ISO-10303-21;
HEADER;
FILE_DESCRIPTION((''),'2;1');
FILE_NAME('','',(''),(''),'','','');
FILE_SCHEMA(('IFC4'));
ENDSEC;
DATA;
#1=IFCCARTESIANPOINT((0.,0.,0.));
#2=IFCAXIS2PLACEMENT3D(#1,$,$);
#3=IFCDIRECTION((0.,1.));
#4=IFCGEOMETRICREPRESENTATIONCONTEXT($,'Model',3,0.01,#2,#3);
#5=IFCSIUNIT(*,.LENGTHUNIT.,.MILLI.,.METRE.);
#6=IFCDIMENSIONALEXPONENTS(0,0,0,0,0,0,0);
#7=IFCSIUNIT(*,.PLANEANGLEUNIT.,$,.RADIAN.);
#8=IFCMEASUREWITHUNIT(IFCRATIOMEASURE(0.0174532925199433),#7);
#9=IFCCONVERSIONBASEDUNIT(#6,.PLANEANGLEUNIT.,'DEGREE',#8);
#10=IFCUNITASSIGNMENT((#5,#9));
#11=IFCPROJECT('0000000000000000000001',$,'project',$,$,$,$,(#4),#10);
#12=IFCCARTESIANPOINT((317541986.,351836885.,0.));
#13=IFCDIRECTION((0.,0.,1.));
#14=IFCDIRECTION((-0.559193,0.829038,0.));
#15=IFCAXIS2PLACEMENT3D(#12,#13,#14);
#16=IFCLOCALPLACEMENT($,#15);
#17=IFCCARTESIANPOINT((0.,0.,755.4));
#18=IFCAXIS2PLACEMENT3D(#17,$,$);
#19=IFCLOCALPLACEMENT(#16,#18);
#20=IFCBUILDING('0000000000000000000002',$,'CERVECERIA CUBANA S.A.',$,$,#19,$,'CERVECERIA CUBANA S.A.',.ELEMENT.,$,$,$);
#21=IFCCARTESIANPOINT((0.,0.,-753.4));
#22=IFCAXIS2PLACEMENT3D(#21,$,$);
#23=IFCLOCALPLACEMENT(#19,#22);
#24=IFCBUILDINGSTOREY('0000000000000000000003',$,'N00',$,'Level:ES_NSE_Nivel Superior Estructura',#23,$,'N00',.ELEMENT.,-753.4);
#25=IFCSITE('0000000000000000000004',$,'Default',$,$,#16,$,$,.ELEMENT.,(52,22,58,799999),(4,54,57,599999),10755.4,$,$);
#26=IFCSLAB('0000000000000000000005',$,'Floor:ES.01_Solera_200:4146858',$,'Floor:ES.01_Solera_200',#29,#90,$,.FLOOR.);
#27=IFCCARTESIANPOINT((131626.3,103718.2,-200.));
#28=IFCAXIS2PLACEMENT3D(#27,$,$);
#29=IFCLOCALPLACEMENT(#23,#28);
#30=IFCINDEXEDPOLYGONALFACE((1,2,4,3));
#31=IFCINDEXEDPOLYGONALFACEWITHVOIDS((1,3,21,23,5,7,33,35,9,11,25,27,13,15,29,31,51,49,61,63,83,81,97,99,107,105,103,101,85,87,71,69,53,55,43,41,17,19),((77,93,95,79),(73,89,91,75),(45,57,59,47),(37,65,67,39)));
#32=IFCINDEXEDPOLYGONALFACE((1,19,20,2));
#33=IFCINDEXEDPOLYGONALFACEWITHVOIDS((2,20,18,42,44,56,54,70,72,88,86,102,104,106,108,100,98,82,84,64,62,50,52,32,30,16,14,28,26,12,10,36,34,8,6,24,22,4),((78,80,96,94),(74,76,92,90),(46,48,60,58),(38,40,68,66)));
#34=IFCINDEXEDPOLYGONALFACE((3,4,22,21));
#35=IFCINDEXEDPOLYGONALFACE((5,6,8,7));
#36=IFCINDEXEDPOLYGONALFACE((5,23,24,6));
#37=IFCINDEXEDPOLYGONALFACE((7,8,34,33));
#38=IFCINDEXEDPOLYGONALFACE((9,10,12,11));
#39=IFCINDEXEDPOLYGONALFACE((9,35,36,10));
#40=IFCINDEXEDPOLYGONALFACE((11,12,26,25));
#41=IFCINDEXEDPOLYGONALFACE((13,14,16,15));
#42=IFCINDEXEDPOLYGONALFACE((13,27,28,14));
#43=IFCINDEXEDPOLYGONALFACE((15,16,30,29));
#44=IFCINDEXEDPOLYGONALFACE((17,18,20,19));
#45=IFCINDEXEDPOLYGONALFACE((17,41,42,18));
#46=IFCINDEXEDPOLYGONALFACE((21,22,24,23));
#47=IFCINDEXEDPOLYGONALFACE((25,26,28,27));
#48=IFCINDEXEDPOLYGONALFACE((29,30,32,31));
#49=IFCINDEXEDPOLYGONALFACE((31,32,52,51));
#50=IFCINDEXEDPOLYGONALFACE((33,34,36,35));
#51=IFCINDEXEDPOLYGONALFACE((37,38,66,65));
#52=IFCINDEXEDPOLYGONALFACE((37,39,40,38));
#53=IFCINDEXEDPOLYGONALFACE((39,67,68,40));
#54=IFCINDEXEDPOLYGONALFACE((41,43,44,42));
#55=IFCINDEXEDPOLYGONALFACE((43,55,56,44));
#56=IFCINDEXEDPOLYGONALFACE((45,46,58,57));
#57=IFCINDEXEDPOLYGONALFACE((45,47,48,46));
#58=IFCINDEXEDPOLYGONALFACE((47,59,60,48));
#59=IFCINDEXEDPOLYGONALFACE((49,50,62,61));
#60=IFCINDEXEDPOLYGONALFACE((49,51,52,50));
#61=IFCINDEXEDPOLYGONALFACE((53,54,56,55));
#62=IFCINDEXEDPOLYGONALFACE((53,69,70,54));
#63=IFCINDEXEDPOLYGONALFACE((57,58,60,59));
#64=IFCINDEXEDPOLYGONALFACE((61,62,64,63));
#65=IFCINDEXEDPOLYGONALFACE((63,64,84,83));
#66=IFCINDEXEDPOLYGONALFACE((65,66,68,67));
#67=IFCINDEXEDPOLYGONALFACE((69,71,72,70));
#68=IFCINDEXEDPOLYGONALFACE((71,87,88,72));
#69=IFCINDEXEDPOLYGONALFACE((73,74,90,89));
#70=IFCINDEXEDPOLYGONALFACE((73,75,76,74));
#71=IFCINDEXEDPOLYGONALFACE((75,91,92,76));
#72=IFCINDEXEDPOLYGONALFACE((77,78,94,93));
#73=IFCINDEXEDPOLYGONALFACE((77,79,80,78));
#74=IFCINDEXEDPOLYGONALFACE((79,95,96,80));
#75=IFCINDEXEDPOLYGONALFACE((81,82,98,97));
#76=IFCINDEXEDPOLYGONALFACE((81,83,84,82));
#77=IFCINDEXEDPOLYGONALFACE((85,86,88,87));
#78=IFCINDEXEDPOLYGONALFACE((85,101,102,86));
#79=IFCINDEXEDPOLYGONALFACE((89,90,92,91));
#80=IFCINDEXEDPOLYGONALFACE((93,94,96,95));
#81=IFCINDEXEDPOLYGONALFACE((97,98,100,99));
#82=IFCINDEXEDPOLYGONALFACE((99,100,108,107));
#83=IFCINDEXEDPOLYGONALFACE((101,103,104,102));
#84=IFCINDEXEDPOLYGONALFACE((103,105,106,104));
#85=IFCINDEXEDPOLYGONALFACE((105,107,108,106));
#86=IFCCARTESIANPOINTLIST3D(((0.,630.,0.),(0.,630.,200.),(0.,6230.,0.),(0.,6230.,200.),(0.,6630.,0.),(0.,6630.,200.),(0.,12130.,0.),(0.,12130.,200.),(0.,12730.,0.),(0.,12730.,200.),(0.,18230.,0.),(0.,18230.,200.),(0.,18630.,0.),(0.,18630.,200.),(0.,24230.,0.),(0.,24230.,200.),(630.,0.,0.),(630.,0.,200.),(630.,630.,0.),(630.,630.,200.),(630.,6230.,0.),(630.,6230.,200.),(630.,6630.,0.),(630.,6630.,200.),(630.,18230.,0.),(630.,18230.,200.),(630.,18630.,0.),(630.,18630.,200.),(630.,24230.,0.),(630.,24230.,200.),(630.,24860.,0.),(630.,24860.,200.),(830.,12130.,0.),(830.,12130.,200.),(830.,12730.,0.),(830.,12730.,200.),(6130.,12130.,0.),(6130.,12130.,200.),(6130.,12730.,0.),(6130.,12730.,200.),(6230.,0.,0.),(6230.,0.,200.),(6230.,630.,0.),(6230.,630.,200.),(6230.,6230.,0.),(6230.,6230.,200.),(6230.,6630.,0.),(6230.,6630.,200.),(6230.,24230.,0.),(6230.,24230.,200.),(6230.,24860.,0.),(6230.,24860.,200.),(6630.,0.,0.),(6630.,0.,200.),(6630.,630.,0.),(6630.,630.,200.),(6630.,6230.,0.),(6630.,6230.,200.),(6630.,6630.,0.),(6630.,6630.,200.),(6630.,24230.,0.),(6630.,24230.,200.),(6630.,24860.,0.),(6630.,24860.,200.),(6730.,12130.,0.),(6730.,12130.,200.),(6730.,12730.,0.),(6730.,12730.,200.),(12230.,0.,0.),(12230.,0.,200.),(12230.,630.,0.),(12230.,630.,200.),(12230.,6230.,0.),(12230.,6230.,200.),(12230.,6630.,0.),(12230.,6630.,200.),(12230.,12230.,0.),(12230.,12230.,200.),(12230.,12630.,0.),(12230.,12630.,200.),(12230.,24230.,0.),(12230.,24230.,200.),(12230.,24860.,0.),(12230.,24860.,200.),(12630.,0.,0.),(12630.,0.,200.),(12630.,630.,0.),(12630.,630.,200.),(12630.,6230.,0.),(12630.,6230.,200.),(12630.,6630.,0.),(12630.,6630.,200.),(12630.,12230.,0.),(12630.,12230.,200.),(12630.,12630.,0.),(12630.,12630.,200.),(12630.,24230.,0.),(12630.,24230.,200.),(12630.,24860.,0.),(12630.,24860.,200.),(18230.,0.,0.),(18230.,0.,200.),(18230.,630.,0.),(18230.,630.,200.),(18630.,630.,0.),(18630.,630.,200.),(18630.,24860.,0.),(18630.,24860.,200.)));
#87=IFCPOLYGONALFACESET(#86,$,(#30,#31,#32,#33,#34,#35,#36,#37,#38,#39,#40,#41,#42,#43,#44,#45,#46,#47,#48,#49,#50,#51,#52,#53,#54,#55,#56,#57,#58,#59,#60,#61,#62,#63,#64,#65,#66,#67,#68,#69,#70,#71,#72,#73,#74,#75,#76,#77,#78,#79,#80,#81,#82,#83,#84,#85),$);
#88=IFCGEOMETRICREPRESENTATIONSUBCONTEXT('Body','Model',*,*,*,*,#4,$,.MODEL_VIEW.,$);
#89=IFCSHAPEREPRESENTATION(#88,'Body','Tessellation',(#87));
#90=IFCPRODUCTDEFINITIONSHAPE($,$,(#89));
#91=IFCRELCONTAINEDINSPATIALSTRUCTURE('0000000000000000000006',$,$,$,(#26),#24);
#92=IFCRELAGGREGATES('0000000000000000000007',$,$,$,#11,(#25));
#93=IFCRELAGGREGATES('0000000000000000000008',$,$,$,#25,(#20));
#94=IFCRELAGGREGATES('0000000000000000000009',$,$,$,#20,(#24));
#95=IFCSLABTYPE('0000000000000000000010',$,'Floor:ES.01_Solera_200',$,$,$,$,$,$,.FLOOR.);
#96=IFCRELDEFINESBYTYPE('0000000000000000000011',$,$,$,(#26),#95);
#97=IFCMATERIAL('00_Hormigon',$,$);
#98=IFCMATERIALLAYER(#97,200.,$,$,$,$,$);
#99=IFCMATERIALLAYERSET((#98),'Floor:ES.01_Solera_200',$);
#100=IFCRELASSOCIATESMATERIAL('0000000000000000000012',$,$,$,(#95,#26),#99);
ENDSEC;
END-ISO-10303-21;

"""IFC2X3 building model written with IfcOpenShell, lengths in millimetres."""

from ifc_helpers import new_model, entity, si_unit, converted_unit, direction, frame, origin, origin_2d_with_axis, place, context, subcontext, project, spatial, polyline, rectangle, outline, extrude, material, layer, layer_set, layer_usage, type_object, element, save


model = new_model("IFC2X3")

# Units and contexts
model_context = context("Model", 3, precision=0.01, world=origin(), true_north=direction((0.0, 1.0)))
body_context = subcontext(model_context, "Body", "Model", "MODEL_VIEW")
ifc_project = project(units=[si_unit("LENGTHUNIT", "METRE", prefix="MILLI"), converted_unit("PLANEANGLEUNIT", "DEGREE", entity("IfcRatioMeasure", 0.0174532925199433), si_unit("PLANEANGLEUNIT", "RADIAN"), dimensions=[0, 0, 0, 0, 0, 0, 0])], contexts=[model_context])

# Site, building, storey
site_placement = place(None, frame((317541986.0, 351836885.0, 0.0), z_axis=(0.0, 0.0, 1.0), x_axis=(-0.559193, 0.829038, 0.0)))
site = spatial("IfcSite", under=ifc_project, at=site_placement, Name="Default", CompositionType="ELEMENT", RefLatitude=(52, 22, 58, 799999), RefLongitude=(4, 54, 57, 599999), RefElevation=10755.4)
building_placement = place(site_placement, frame((0.0, 0.0, 755.4)))
building = spatial("IfcBuilding", under=site, at=building_placement, Name="CERVECERIA CUBANA S.A.", LongName="CERVECERIA CUBANA S.A.", CompositionType="ELEMENT")
storey_placement = place(building_placement, frame((0.0, 0.0, -753.4)))
storey = spatial("IfcBuildingStorey", under=building, at=storey_placement, Name="N00", ObjectType="Level:ES_NSE_Nivel Superior Estructura", LongName="N00", CompositionType="ELEMENT", Elevation=-753.4)

# Slab, openings
ifc_material = material(Name="00_Hormigon")
ifc_layer_1 = layer(ifc_material, 200.0)
ifc_layer_set_1 = layer_set([ifc_layer_1], Name="Floor:ES.01_Solera_200")
ifc_layer_usage_1 = layer_usage(ifc_layer_set_1, "AXIS3", "POSITIVE", 0.0)
slab_type = type_object("IfcSlabType", Name="Floor:ES.01_Solera_200", PredefinedType="FLOOR", material=ifc_layer_set_1)
slab_placement = place(storey_placement, frame((131626.3, 103718.2, -200.0)))
slab = element("IfcSlab", 1, at=slab_placement, inside=storey, type_object=slab_type, material=ifc_layer_usage_1, Name="Floor:ES.01_Solera_200:4146858", ObjectType="Floor:ES.01_Solera_200", PredefinedType="FLOOR", context=body_context, shape_type="SweptSolid", body=[
    extrude(outline(polyline([(9315.0, 6200.0), (9315.0, 11800.0), (8685.0, 11800.0), (8685.0, 12430.0), (3085.0, 12430.0), (3085.0, 11800.0), (2685.0, 11800.0), (2685.0, 12430.0), (-2915.0, 12430.0), (-2915.0, 11800.0), (-3315.0, 11800.0), (-3315.0, 12430.0), (-9315.0, 12430.0), (-9315.0, -11800.0), (-8915.0, -11800.0), (-8915.0, -12430.0), (-3315.0, -12430.0), (-3315.0, -11800.0), (-2915.0, -11800.0), (-2915.0, -12430.0), (2685.0, -12430.0), (2685.0, -11800.0), (3085.0, -11800.0), (3085.0, -12430.0), (8685.0, -12430.0), (8685.0, -11800.0), (9315.0, -11800.0), (9315.0, -6200.0), (8685.0, -6200.0), (8685.0, -5800.0), (9315.0, -5800.0), (9315.0, -300.0), (8485.0, -300.0), (8485.0, 300.0), (9315.0, 300.0), (9315.0, 5800.0), (8685.0, 5800.0), (8685.0, 6200.0), (9315.0, 6200.0)])), frame((9315.0, 12430.0, 200.0), z_axis=(0.0, 0.0, -1.0), x_axis=(-1.0, 0.0, 0.0)), (0.0, 0.0, 1.0), 200.0),
])
opening_1_placement = place(slab_placement, frame((12430.0, 12430.0, 200.0)))
element("IfcOpeningElement", 2, at=opening_1_placement, cuts=slab, ObjectType="Opening", context=body_context, shape_type="SweptSolid", body=[
    extrude(rectangle(XDim=400.0, YDim=400.0, at=origin_2d_with_axis()), frame((0.0, 0.0, 0.0), z_axis=(0.0, 0.0, -1.0), x_axis=(0.0, -1.0, 0.0)), (0.0, 0.0, 1.0), 200.0),
])
opening_2_placement = place(slab_placement, frame((6430.0, 12430.0, 200.0)))
element("IfcOpeningElement", 3, at=opening_2_placement, cuts=slab, ObjectType="Opening", context=body_context, shape_type="SweptSolid", body=[
    extrude(rectangle(XDim=600.0, YDim=600.0, at=origin_2d_with_axis()), frame((0.0, 0.0, 0.0), z_axis=(0.0, 0.0, -1.0), x_axis=(0.0, -1.0, 0.0)), (0.0, 0.0, 1.0), 200.0),
])
opening_3_placement = place(slab_placement, frame((6430.0, 6430.0, 200.0)))
element("IfcOpeningElement", 4, at=opening_3_placement, cuts=slab, ObjectType="Opening", context=body_context, shape_type="SweptSolid", body=[
    extrude(rectangle(XDim=400.0, YDim=400.0, at=origin_2d_with_axis()), frame((0.0, 0.0, 0.0), z_axis=(0.0, 0.0, -1.0), x_axis=(1.0, 0.0, 0.0)), (0.0, 0.0, 1.0), 200.0),
])
opening_4_placement = place(slab_placement, frame((12430.0, 6430.0, 200.0)))
element("IfcOpeningElement", 5, at=opening_4_placement, cuts=slab, ObjectType="Opening", context=body_context, shape_type="SweptSolid", body=[
    extrude(rectangle(XDim=400.0, YDim=400.0, at=origin_2d_with_axis()), frame((0.0, 0.0, 0.0), z_axis=(0.0, 0.0, -1.0), x_axis=(0.0, -1.0, 0.0)), (0.0, 0.0, 1.0), 200.0),
])

save(model, "model.ifc")
